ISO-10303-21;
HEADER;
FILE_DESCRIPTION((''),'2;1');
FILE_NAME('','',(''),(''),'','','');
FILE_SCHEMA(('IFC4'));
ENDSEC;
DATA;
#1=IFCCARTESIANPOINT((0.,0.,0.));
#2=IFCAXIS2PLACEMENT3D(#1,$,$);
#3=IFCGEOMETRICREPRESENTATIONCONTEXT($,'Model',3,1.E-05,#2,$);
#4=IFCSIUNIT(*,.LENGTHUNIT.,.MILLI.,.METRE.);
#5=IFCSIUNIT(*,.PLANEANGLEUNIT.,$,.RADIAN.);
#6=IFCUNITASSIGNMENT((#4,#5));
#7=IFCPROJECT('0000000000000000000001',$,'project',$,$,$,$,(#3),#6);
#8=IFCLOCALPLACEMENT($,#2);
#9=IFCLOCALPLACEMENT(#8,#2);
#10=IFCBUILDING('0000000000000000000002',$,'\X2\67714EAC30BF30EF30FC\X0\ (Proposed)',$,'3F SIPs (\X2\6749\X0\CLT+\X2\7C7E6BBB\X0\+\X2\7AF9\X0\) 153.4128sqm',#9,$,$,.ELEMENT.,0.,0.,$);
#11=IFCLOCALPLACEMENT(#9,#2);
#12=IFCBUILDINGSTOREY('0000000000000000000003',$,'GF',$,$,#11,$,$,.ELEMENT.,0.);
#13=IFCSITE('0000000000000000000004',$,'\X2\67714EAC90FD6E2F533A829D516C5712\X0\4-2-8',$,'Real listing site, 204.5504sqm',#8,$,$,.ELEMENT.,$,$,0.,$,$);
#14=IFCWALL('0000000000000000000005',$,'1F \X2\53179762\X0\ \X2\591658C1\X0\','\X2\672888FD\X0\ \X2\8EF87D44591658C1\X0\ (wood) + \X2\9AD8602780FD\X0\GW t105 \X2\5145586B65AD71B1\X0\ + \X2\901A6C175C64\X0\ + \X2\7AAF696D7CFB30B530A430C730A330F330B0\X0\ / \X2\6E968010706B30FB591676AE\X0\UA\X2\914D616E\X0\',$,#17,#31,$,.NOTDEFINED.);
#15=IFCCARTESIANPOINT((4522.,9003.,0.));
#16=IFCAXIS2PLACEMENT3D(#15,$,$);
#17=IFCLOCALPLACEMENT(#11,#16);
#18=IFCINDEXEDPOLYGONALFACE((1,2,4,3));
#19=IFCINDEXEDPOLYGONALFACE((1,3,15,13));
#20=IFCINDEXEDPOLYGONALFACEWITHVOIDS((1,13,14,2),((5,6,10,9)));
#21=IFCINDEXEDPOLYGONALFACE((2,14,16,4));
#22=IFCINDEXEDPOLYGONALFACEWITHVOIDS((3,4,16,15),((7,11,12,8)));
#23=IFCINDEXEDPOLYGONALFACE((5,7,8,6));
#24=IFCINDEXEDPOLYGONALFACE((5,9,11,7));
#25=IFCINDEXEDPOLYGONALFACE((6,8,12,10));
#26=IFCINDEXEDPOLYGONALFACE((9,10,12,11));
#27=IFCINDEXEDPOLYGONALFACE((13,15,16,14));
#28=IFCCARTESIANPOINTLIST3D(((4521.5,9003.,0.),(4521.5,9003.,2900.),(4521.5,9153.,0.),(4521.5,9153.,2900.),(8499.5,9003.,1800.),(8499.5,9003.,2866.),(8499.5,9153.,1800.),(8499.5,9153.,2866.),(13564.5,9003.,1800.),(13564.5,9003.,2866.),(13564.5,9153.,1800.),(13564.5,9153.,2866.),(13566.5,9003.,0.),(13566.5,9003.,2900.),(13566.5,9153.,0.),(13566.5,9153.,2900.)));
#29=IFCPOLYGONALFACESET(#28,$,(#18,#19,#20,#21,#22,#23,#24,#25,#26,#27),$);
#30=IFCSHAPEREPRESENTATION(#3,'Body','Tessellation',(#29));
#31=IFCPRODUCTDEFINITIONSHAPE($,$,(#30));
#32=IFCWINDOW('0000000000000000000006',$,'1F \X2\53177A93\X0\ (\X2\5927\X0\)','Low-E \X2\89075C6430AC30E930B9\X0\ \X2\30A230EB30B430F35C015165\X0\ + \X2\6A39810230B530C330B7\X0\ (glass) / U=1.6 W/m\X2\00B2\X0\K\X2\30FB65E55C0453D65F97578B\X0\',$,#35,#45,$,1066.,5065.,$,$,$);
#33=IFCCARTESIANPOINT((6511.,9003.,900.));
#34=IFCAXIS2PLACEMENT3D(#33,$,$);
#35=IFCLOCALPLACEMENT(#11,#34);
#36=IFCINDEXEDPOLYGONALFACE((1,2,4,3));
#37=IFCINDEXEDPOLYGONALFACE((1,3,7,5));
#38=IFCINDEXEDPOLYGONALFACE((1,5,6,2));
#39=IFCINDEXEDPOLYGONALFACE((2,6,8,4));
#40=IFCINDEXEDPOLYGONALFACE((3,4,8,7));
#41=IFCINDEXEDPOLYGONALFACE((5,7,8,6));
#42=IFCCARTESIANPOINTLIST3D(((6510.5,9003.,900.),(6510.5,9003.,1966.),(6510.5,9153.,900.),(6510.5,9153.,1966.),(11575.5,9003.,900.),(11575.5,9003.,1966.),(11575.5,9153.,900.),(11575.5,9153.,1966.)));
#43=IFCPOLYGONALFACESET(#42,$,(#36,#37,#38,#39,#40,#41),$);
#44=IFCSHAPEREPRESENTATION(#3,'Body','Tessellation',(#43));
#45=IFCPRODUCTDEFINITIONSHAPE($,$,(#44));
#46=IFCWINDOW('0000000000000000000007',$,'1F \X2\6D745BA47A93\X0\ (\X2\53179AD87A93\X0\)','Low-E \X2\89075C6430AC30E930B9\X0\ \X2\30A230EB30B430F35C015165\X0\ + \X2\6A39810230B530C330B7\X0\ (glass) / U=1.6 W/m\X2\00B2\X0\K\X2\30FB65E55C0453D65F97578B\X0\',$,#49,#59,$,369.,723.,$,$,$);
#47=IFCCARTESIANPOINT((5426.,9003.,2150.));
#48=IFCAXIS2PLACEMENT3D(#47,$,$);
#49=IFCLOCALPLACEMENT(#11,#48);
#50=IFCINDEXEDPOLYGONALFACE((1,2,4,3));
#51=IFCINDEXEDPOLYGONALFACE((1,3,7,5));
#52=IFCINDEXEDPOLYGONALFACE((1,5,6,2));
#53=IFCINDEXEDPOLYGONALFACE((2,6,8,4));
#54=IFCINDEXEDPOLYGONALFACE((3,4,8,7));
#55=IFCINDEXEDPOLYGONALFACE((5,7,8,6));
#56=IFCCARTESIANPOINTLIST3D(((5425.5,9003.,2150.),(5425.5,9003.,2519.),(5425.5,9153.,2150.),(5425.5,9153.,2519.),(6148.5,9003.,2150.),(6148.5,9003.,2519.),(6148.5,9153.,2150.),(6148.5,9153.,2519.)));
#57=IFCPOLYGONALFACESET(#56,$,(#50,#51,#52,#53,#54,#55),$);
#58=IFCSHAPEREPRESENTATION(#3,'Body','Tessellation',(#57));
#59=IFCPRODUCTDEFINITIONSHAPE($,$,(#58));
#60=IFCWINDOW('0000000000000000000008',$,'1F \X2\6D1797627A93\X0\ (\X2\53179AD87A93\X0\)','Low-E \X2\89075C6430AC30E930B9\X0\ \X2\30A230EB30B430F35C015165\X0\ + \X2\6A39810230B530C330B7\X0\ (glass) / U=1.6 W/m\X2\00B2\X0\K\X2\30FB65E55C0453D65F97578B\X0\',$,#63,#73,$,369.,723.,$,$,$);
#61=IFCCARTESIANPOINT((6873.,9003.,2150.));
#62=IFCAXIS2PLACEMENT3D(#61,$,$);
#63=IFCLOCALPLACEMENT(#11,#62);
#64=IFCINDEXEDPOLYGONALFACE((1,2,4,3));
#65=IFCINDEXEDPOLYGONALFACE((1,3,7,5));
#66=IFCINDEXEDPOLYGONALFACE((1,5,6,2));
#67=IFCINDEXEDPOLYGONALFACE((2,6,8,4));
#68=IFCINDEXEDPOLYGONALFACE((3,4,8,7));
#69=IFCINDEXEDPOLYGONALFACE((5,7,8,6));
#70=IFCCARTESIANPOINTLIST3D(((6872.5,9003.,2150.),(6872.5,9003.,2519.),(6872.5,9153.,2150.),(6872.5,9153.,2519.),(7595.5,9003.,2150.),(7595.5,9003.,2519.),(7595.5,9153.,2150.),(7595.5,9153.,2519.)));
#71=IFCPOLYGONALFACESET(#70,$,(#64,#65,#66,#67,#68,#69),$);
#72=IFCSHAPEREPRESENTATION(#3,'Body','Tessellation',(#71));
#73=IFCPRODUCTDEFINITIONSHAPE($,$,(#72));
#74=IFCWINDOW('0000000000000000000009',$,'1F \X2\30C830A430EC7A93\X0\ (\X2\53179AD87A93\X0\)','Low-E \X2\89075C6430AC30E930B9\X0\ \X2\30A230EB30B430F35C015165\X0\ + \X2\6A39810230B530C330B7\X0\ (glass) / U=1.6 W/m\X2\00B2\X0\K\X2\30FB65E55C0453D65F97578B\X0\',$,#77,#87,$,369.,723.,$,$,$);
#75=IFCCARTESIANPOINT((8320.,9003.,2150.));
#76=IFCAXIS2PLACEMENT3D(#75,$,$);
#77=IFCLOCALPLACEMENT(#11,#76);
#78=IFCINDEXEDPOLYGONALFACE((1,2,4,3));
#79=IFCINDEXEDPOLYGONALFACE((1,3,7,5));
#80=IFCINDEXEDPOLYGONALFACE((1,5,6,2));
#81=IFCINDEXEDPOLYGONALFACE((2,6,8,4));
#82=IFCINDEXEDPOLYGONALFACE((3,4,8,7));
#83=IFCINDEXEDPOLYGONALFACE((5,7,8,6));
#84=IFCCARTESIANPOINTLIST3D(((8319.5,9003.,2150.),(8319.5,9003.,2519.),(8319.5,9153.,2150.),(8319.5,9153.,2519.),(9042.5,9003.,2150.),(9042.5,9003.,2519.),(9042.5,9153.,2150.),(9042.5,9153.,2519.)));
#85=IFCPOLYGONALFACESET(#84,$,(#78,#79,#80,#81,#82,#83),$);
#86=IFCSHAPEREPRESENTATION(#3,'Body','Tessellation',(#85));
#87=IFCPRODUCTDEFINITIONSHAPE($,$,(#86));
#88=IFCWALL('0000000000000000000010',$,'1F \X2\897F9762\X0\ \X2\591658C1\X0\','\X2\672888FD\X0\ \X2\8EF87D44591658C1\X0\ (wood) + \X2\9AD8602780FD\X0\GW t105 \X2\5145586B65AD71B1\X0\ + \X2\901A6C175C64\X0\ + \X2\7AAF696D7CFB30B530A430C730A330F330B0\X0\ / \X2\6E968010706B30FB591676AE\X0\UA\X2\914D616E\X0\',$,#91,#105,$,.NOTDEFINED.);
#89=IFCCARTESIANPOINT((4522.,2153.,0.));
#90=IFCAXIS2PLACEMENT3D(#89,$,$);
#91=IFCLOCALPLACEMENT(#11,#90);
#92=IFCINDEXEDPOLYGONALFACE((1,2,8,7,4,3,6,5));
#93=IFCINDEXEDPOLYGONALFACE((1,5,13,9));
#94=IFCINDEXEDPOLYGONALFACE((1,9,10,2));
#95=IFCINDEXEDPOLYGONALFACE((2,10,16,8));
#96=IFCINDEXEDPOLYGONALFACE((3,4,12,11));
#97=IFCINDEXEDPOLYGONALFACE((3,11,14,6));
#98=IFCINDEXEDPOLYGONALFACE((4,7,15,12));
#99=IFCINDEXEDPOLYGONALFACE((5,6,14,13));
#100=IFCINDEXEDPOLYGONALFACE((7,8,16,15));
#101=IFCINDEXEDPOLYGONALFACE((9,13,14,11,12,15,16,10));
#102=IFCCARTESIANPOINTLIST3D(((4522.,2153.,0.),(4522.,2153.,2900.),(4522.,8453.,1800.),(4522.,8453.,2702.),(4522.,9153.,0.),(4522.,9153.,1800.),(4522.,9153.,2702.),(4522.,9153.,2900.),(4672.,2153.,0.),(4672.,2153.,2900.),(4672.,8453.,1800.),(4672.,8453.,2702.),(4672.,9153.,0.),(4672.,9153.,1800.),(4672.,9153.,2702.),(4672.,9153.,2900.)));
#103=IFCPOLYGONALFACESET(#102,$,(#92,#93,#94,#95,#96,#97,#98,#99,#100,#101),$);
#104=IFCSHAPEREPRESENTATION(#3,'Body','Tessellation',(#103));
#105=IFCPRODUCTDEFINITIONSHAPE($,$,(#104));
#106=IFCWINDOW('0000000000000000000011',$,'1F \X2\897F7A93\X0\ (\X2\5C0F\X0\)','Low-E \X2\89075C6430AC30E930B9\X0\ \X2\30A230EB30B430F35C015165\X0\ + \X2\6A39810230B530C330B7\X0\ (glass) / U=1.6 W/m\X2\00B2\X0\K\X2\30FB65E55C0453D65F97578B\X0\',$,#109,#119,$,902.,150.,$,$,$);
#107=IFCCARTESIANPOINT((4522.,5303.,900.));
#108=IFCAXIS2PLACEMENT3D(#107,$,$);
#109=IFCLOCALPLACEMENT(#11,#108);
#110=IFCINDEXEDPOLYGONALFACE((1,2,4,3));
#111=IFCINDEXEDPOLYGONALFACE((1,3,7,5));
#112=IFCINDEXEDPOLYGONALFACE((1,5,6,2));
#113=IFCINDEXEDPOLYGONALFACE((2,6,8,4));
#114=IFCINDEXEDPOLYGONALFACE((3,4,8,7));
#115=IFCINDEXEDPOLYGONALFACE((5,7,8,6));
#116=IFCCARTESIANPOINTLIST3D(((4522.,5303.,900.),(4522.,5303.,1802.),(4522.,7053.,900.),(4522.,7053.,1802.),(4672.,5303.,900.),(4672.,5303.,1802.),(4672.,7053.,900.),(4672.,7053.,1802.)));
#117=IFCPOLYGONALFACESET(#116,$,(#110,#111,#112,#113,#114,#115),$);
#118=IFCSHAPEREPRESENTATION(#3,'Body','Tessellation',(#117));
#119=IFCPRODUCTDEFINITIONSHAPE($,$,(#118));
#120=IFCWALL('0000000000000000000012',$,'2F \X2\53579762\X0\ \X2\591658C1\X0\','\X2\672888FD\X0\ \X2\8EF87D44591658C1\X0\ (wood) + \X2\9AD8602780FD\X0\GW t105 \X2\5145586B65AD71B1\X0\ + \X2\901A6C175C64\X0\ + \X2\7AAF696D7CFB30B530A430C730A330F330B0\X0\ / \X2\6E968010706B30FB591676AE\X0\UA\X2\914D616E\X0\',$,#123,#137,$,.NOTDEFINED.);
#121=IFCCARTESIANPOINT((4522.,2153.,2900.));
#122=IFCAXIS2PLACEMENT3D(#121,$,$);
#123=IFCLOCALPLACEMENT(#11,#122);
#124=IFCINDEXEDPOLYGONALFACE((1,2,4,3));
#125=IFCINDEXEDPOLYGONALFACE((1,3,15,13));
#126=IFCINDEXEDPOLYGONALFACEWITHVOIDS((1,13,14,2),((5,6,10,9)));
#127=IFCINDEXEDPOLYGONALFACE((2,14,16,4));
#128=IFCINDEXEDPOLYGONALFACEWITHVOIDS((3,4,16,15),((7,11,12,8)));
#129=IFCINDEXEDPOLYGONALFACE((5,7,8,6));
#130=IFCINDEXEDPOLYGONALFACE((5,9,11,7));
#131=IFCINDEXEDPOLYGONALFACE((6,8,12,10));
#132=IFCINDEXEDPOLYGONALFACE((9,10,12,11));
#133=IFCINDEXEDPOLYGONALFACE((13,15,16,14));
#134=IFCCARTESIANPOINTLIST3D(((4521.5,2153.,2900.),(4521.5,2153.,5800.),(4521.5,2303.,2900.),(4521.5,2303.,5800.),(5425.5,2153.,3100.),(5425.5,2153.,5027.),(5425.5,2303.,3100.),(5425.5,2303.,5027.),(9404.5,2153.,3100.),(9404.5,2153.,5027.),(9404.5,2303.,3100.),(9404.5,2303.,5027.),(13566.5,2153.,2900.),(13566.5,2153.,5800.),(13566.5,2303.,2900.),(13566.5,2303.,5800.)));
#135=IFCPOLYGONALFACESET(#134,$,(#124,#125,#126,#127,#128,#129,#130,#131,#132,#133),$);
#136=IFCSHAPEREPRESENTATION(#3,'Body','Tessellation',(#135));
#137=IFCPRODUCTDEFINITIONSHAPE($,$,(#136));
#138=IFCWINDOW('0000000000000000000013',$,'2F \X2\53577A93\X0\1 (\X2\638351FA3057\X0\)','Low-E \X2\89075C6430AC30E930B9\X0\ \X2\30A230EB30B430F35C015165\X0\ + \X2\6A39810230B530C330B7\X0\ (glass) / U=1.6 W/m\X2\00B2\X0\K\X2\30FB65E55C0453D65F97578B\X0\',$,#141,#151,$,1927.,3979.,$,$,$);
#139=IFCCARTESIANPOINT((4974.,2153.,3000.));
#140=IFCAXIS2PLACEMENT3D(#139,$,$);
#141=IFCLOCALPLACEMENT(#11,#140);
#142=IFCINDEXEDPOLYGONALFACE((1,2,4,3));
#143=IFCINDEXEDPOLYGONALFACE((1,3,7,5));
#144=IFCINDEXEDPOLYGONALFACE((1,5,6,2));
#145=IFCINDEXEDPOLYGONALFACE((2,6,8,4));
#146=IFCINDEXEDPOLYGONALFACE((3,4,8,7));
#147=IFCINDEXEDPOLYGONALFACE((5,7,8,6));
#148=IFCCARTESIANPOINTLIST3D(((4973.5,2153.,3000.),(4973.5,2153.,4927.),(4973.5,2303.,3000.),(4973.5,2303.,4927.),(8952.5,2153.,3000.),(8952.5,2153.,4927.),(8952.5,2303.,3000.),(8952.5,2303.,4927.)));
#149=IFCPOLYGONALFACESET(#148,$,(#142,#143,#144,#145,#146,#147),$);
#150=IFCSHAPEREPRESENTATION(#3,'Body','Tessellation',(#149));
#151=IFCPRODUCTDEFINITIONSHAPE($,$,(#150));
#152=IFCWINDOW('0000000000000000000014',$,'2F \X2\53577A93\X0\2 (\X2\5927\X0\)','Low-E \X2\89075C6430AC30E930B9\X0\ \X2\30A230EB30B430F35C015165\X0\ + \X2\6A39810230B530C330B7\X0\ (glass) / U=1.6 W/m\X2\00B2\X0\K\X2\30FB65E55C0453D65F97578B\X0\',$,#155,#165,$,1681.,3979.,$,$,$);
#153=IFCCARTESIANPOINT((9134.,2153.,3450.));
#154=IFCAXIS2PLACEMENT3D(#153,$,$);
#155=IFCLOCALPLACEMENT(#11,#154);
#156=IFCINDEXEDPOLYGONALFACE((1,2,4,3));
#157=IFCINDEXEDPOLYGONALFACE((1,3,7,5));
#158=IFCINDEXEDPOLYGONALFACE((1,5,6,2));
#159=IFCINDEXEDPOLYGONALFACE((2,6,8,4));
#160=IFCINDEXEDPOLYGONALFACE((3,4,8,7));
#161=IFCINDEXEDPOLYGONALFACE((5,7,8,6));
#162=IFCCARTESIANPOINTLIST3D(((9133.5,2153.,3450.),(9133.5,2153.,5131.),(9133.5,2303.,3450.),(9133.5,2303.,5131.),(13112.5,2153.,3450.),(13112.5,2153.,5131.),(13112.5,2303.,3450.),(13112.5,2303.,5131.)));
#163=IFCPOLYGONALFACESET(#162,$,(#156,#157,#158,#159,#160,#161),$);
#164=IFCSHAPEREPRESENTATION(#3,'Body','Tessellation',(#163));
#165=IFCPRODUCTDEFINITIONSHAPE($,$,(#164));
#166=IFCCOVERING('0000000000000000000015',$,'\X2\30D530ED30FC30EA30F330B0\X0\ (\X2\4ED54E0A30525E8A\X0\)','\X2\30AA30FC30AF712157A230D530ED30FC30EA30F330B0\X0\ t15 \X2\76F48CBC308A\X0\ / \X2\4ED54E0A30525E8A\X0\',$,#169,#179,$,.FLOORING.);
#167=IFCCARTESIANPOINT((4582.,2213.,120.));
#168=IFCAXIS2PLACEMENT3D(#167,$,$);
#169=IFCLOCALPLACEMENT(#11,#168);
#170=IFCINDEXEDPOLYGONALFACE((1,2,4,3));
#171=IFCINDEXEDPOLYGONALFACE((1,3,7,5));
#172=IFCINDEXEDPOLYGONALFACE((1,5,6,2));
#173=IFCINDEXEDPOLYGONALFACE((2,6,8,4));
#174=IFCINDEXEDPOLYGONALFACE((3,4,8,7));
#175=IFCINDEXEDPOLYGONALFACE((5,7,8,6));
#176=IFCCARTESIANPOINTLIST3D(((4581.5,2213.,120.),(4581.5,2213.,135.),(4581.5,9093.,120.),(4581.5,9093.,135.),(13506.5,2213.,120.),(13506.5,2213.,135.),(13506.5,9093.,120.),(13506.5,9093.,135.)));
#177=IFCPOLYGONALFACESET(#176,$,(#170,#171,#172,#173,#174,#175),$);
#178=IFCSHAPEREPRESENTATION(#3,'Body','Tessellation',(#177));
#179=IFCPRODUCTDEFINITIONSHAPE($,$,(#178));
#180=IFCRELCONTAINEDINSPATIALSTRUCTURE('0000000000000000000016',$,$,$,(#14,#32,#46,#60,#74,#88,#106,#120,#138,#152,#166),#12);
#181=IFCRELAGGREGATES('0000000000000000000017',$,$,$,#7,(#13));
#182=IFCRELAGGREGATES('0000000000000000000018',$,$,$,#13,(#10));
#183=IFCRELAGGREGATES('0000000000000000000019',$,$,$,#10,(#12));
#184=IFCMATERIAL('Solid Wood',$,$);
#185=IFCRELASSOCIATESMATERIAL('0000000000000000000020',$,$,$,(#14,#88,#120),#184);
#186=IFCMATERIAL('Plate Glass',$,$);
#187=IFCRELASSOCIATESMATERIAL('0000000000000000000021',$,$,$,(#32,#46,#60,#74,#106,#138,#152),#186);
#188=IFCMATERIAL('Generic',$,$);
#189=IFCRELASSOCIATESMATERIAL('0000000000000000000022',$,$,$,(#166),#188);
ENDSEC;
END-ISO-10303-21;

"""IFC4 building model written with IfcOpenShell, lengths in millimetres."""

from ifc_helpers import new_model, si_unit, frame, frame_2d, origin, place, context, project, spatial, rectangle, extrude, material, element, fill, save


model = new_model("IFC4")

# Units and contexts
model_context = context("Model", 3, precision=1e-05, world=origin())
ifc_project = project(units=[si_unit("LENGTHUNIT", "METRE", prefix="MILLI"), si_unit("PLANEANGLEUNIT", "RADIAN")], contexts=[model_context])

# Site, building, storey
site_placement = place(None, origin())
site = spatial("IfcSite", under=ifc_project, at=site_placement, Name="東京都港区芝公園4-2-8", ObjectType="Real listing site, 204.5504sqm", CompositionType="ELEMENT", RefElevation=0.0)
building_placement = place(site_placement, origin())
building = spatial("IfcBuilding", under=site, at=building_placement, Name="東京タワー (Proposed)", ObjectType="3F SIPs (杉CLT+籾殻+竹) 153.4128sqm", CompositionType="ELEMENT", ElevationOfRefHeight=0.0, ElevationOfTerrain=0.0)
storey_placement = place(building_placement, origin())
storey = spatial("IfcBuildingStorey", under=building, at=storey_placement, Name="GF", CompositionType="ELEMENT", Elevation=0.0)

# Shared definitions
ifc_material_1 = material(Name="Solid Wood")

# Shared definitions
ifc_material_2 = material(Name="Plate Glass")

# Wall, openings, windows
wall_1_placement = place(storey_placement, frame((4522.0, 9003.0, 0.0)))
wall_1 = element("IfcWall", 1, at=wall_1_placement, inside=storey, material=ifc_material_1, Name="1F 北面 外壁", Description="木製 軸組外壁 (wood) + 高性能GW t105 充填断熱 + 通気層 + 窯業系サイディング / 準耐火・外皮UA配慮", PredefinedType="NOTDEFINED", context=model_context, shape_type="SweptSolid", body=[
    extrude(rectangle(XDim=9045.0, YDim=150.0, at=frame_2d((4522.0, 75.0))), frame((4522.0, 9003.0, 0.0)), (0.0, 0.0, 1.0), 2900.0),
])
opening_1_placement = place(storey_placement, frame((6511.0, 9003.0, 900.0)))
opening_1 = element("IfcOpeningElement", 2, at=opening_1_placement, cuts=wall_1, PredefinedType="NOTDEFINED", context=model_context, shape_type="SweptSolid", body=[
    extrude(rectangle(XDim=5065.0, YDim=150.0, at=frame_2d((2532.0, 75.0))), frame((6511.0, 9003.0, 900.0)), (0.0, 0.0, 1.0), 1066.0),
])
opening_2_placement = place(storey_placement, frame((5426.0, 9003.0, 2150.0)))
opening_2 = element("IfcOpeningElement", 3, at=opening_2_placement, cuts=wall_1, PredefinedType="NOTDEFINED", context=model_context, shape_type="SweptSolid", body=[
    extrude(rectangle(XDim=723.0, YDim=150.0, at=frame_2d((361.0, 75.0))), frame((5426.0, 9003.0, 2150.0)), (0.0, 0.0, 1.0), 369.0),
])
opening_3_placement = place(storey_placement, frame((6873.0, 9003.0, 2150.0)))
opening_3 = element("IfcOpeningElement", 4, at=opening_3_placement, cuts=wall_1, PredefinedType="NOTDEFINED", context=model_context, shape_type="SweptSolid", body=[
    extrude(rectangle(XDim=723.0, YDim=150.0, at=frame_2d((361.0, 75.0))), frame((6873.0, 9003.0, 2150.0)), (0.0, 0.0, 1.0), 369.0),
])
opening_4_placement = place(storey_placement, frame((8320.0, 9003.0, 2150.0)))
opening_4 = element("IfcOpeningElement", 5, at=opening_4_placement, cuts=wall_1, PredefinedType="NOTDEFINED", context=model_context, shape_type="SweptSolid", body=[
    extrude(rectangle(XDim=723.0, YDim=150.0, at=frame_2d((361.0, 75.0))), frame((8320.0, 9003.0, 2150.0)), (0.0, 0.0, 1.0), 369.0),
])
window_1_placement = place(storey_placement, frame((6511.0, 9003.0, 900.0)))
window_1 = element("IfcWindow", 6, at=window_1_placement, inside=storey, material=ifc_material_2, Name="1F 北窓 (大)", Description="Low-E 複層ガラス アルゴン封入 + 樹脂サッシ (glass) / U=1.6 W/m²K・日射取得型", OverallHeight=1066.0, OverallWidth=5065.0, context=model_context, shape_type="SweptSolid", body=[
    extrude(rectangle(XDim=5065.0, YDim=150.0, at=frame_2d((2532.0, 75.0))), frame((6511.0, 9003.0, 900.0)), (0.0, 0.0, 1.0), 1066.0),
])
fill(opening_1, window_1)
window_2_placement = place(storey_placement, frame((5426.0, 9003.0, 2150.0)))
window_2 = element("IfcWindow", 7, at=window_2_placement, inside=storey, material=ifc_material_2, Name="1F 浴室窓 (北高窓)", Description="Low-E 複層ガラス アルゴン封入 + 樹脂サッシ (glass) / U=1.6 W/m²K・日射取得型", OverallHeight=369.0, OverallWidth=723.0, context=model_context, shape_type="SweptSolid", body=[
    extrude(rectangle(XDim=723.0, YDim=150.0, at=frame_2d((361.0, 75.0))), frame((5426.0, 9003.0, 2150.0)), (0.0, 0.0, 1.0), 369.0),
])
fill(opening_2, window_2)
window_3_placement = place(storey_placement, frame((6873.0, 9003.0, 2150.0)))
window_3 = element("IfcWindow", 8, at=window_3_placement, inside=storey, material=ifc_material_2, Name="1F 洗面窓 (北高窓)", Description="Low-E 複層ガラス アルゴン封入 + 樹脂サッシ (glass) / U=1.6 W/m²K・日射取得型", OverallHeight=369.0, OverallWidth=723.0, context=model_context, shape_type="SweptSolid", body=[
    extrude(rectangle(XDim=723.0, YDim=150.0, at=frame_2d((361.0, 75.0))), frame((6873.0, 9003.0, 2150.0)), (0.0, 0.0, 1.0), 369.0),
])
fill(opening_3, window_3)
window_4_placement = place(storey_placement, frame((8320.0, 9003.0, 2150.0)))
window_4 = element("IfcWindow", 9, at=window_4_placement, inside=storey, material=ifc_material_2, Name="1F トイレ窓 (北高窓)", Description="Low-E 複層ガラス アルゴン封入 + 樹脂サッシ (glass) / U=1.6 W/m²K・日射取得型", OverallHeight=369.0, OverallWidth=723.0, context=model_context, shape_type="SweptSolid", body=[
    extrude(rectangle(XDim=723.0, YDim=150.0, at=frame_2d((361.0, 75.0))), frame((8320.0, 9003.0, 2150.0)), (0.0, 0.0, 1.0), 369.0),
])
fill(opening_4, window_4)

# Wall, opening, window
wall_2_placement = place(storey_placement, frame((4522.0, 2153.0, 0.0)))
wall_2 = element("IfcWall", 10, at=wall_2_placement, inside=storey, material=ifc_material_1, Name="1F 西面 外壁", Description="木製 軸組外壁 (wood) + 高性能GW t105 充填断熱 + 通気層 + 窯業系サイディング / 準耐火・外皮UA配慮", PredefinedType="NOTDEFINED", context=model_context, shape_type="SweptSolid", body=[
    extrude(rectangle(XDim=150.0, YDim=7000.0, at=frame_2d((75.0, 3500.0))), frame((4522.0, 2153.0, 0.0)), (0.0, 0.0, 1.0), 2900.0),
])
opening_5_placement = place(storey_placement, frame((4522.0, 5303.0, 900.0)))
opening_5 = element("IfcOpeningElement", 11, at=opening_5_placement, cuts=wall_2, PredefinedType="NOTDEFINED", context=model_context, shape_type="SweptSolid", body=[
    extrude(rectangle(XDim=150.0, YDim=1750.0, at=frame_2d((75.0, 875.0))), frame((4522.0, 5303.0, 900.0)), (0.0, 0.0, 1.0), 902.0),
])
window_5_placement = place(storey_placement, frame((4522.0, 5303.0, 900.0)))
window_5 = element("IfcWindow", 12, at=window_5_placement, inside=storey, material=ifc_material_2, Name="1F 西窓 (小)", Description="Low-E 複層ガラス アルゴン封入 + 樹脂サッシ (glass) / U=1.6 W/m²K・日射取得型", OverallHeight=902.0, OverallWidth=150.0, context=model_context, shape_type="SweptSolid", body=[
    extrude(rectangle(XDim=150.0, YDim=1750.0, at=frame_2d((75.0, 875.0))), frame((4522.0, 5303.0, 900.0)), (0.0, 0.0, 1.0), 902.0),
])
fill(opening_5, window_5)

# Wall, openings, windows
wall_3_placement = place(storey_placement, frame((4522.0, 2153.0, 2900.0)))
wall_3 = element("IfcWall", 13, at=wall_3_placement, inside=storey, material=ifc_material_1, Name="2F 南面 外壁", Description="木製 軸組外壁 (wood) + 高性能GW t105 充填断熱 + 通気層 + 窯業系サイディング / 準耐火・外皮UA配慮", PredefinedType="NOTDEFINED", context=model_context, shape_type="SweptSolid", body=[
    extrude(rectangle(XDim=9045.0, YDim=150.0, at=frame_2d((4522.0, 75.0))), frame((4522.0, 2153.0, 2900.0)), (0.0, 0.0, 1.0), 2900.0),
])
opening_6_placement = place(storey_placement, frame((4974.0, 2153.0, 3000.0)))
opening_6 = element("IfcOpeningElement", 14, at=opening_6_placement, cuts=wall_3, PredefinedType="NOTDEFINED", context=model_context, shape_type="SweptSolid", body=[
    extrude(rectangle(XDim=3979.0, YDim=150.0, at=frame_2d((1989.0, 75.0))), frame((4974.0, 2153.0, 3000.0)), (0.0, 0.0, 1.0), 1927.0),
])
opening_7_placement = place(storey_placement, frame((9134.0, 2153.0, 3450.0)))
opening_7 = element("IfcOpeningElement", 15, at=opening_7_placement, cuts=wall_3, PredefinedType="NOTDEFINED", context=model_context, shape_type="SweptSolid", body=[
    extrude(rectangle(XDim=3979.0, YDim=150.0, at=frame_2d((1989.0, 75.0))), frame((9134.0, 2153.0, 3450.0)), (0.0, 0.0, 1.0), 1681.0),
])
window_6_placement = place(storey_placement, frame((4974.0, 2153.0, 3000.0)))
window_6 = element("IfcWindow", 16, at=window_6_placement, inside=storey, material=ifc_material_2, Name="2F 南窓1 (掃出し)", Description="Low-E 複層ガラス アルゴン封入 + 樹脂サッシ (glass) / U=1.6 W/m²K・日射取得型", OverallHeight=1927.0, OverallWidth=3979.0, context=model_context, shape_type="SweptSolid", body=[
    extrude(rectangle(XDim=3979.0, YDim=150.0, at=frame_2d((1989.0, 75.0))), frame((4974.0, 2153.0, 3000.0)), (0.0, 0.0, 1.0), 1927.0),
])
fill(opening_6, window_6)
window_7_placement = place(storey_placement, frame((9134.0, 2153.0, 3450.0)))
window_7 = element("IfcWindow", 17, at=window_7_placement, inside=storey, material=ifc_material_2, Name="2F 南窓2 (大)", Description="Low-E 複層ガラス アルゴン封入 + 樹脂サッシ (glass) / U=1.6 W/m²K・日射取得型", OverallHeight=1681.0, OverallWidth=3979.0, context=model_context, shape_type="SweptSolid", body=[
    extrude(rectangle(XDim=3979.0, YDim=150.0, at=frame_2d((1989.0, 75.0))), frame((9134.0, 2153.0, 3450.0)), (0.0, 0.0, 1.0), 1681.0),
])
fill(opening_7, window_7)

# Covering
ifc_material_3 = material(Name="Generic")
covering_placement = place(storey_placement, frame((4582.0, 2213.0, 120.0)))
element("IfcCovering", 18, at=covering_placement, inside=storey, material=ifc_material_3, Name="フローリング (仕上げ床)", Description="オーク無垢フローリング t15 直貼り / 仕上げ床", PredefinedType="FLOORING", context=model_context, shape_type="SweptSolid", body=[
    extrude(rectangle(XDim=8925.0, YDim=6880.0, at=frame_2d((4462.0, 3440.0))), frame((4582.0, 2213.0, 120.0)), (0.0, 0.0, 1.0), 15.0),
])

save(model, "model.ifc")
